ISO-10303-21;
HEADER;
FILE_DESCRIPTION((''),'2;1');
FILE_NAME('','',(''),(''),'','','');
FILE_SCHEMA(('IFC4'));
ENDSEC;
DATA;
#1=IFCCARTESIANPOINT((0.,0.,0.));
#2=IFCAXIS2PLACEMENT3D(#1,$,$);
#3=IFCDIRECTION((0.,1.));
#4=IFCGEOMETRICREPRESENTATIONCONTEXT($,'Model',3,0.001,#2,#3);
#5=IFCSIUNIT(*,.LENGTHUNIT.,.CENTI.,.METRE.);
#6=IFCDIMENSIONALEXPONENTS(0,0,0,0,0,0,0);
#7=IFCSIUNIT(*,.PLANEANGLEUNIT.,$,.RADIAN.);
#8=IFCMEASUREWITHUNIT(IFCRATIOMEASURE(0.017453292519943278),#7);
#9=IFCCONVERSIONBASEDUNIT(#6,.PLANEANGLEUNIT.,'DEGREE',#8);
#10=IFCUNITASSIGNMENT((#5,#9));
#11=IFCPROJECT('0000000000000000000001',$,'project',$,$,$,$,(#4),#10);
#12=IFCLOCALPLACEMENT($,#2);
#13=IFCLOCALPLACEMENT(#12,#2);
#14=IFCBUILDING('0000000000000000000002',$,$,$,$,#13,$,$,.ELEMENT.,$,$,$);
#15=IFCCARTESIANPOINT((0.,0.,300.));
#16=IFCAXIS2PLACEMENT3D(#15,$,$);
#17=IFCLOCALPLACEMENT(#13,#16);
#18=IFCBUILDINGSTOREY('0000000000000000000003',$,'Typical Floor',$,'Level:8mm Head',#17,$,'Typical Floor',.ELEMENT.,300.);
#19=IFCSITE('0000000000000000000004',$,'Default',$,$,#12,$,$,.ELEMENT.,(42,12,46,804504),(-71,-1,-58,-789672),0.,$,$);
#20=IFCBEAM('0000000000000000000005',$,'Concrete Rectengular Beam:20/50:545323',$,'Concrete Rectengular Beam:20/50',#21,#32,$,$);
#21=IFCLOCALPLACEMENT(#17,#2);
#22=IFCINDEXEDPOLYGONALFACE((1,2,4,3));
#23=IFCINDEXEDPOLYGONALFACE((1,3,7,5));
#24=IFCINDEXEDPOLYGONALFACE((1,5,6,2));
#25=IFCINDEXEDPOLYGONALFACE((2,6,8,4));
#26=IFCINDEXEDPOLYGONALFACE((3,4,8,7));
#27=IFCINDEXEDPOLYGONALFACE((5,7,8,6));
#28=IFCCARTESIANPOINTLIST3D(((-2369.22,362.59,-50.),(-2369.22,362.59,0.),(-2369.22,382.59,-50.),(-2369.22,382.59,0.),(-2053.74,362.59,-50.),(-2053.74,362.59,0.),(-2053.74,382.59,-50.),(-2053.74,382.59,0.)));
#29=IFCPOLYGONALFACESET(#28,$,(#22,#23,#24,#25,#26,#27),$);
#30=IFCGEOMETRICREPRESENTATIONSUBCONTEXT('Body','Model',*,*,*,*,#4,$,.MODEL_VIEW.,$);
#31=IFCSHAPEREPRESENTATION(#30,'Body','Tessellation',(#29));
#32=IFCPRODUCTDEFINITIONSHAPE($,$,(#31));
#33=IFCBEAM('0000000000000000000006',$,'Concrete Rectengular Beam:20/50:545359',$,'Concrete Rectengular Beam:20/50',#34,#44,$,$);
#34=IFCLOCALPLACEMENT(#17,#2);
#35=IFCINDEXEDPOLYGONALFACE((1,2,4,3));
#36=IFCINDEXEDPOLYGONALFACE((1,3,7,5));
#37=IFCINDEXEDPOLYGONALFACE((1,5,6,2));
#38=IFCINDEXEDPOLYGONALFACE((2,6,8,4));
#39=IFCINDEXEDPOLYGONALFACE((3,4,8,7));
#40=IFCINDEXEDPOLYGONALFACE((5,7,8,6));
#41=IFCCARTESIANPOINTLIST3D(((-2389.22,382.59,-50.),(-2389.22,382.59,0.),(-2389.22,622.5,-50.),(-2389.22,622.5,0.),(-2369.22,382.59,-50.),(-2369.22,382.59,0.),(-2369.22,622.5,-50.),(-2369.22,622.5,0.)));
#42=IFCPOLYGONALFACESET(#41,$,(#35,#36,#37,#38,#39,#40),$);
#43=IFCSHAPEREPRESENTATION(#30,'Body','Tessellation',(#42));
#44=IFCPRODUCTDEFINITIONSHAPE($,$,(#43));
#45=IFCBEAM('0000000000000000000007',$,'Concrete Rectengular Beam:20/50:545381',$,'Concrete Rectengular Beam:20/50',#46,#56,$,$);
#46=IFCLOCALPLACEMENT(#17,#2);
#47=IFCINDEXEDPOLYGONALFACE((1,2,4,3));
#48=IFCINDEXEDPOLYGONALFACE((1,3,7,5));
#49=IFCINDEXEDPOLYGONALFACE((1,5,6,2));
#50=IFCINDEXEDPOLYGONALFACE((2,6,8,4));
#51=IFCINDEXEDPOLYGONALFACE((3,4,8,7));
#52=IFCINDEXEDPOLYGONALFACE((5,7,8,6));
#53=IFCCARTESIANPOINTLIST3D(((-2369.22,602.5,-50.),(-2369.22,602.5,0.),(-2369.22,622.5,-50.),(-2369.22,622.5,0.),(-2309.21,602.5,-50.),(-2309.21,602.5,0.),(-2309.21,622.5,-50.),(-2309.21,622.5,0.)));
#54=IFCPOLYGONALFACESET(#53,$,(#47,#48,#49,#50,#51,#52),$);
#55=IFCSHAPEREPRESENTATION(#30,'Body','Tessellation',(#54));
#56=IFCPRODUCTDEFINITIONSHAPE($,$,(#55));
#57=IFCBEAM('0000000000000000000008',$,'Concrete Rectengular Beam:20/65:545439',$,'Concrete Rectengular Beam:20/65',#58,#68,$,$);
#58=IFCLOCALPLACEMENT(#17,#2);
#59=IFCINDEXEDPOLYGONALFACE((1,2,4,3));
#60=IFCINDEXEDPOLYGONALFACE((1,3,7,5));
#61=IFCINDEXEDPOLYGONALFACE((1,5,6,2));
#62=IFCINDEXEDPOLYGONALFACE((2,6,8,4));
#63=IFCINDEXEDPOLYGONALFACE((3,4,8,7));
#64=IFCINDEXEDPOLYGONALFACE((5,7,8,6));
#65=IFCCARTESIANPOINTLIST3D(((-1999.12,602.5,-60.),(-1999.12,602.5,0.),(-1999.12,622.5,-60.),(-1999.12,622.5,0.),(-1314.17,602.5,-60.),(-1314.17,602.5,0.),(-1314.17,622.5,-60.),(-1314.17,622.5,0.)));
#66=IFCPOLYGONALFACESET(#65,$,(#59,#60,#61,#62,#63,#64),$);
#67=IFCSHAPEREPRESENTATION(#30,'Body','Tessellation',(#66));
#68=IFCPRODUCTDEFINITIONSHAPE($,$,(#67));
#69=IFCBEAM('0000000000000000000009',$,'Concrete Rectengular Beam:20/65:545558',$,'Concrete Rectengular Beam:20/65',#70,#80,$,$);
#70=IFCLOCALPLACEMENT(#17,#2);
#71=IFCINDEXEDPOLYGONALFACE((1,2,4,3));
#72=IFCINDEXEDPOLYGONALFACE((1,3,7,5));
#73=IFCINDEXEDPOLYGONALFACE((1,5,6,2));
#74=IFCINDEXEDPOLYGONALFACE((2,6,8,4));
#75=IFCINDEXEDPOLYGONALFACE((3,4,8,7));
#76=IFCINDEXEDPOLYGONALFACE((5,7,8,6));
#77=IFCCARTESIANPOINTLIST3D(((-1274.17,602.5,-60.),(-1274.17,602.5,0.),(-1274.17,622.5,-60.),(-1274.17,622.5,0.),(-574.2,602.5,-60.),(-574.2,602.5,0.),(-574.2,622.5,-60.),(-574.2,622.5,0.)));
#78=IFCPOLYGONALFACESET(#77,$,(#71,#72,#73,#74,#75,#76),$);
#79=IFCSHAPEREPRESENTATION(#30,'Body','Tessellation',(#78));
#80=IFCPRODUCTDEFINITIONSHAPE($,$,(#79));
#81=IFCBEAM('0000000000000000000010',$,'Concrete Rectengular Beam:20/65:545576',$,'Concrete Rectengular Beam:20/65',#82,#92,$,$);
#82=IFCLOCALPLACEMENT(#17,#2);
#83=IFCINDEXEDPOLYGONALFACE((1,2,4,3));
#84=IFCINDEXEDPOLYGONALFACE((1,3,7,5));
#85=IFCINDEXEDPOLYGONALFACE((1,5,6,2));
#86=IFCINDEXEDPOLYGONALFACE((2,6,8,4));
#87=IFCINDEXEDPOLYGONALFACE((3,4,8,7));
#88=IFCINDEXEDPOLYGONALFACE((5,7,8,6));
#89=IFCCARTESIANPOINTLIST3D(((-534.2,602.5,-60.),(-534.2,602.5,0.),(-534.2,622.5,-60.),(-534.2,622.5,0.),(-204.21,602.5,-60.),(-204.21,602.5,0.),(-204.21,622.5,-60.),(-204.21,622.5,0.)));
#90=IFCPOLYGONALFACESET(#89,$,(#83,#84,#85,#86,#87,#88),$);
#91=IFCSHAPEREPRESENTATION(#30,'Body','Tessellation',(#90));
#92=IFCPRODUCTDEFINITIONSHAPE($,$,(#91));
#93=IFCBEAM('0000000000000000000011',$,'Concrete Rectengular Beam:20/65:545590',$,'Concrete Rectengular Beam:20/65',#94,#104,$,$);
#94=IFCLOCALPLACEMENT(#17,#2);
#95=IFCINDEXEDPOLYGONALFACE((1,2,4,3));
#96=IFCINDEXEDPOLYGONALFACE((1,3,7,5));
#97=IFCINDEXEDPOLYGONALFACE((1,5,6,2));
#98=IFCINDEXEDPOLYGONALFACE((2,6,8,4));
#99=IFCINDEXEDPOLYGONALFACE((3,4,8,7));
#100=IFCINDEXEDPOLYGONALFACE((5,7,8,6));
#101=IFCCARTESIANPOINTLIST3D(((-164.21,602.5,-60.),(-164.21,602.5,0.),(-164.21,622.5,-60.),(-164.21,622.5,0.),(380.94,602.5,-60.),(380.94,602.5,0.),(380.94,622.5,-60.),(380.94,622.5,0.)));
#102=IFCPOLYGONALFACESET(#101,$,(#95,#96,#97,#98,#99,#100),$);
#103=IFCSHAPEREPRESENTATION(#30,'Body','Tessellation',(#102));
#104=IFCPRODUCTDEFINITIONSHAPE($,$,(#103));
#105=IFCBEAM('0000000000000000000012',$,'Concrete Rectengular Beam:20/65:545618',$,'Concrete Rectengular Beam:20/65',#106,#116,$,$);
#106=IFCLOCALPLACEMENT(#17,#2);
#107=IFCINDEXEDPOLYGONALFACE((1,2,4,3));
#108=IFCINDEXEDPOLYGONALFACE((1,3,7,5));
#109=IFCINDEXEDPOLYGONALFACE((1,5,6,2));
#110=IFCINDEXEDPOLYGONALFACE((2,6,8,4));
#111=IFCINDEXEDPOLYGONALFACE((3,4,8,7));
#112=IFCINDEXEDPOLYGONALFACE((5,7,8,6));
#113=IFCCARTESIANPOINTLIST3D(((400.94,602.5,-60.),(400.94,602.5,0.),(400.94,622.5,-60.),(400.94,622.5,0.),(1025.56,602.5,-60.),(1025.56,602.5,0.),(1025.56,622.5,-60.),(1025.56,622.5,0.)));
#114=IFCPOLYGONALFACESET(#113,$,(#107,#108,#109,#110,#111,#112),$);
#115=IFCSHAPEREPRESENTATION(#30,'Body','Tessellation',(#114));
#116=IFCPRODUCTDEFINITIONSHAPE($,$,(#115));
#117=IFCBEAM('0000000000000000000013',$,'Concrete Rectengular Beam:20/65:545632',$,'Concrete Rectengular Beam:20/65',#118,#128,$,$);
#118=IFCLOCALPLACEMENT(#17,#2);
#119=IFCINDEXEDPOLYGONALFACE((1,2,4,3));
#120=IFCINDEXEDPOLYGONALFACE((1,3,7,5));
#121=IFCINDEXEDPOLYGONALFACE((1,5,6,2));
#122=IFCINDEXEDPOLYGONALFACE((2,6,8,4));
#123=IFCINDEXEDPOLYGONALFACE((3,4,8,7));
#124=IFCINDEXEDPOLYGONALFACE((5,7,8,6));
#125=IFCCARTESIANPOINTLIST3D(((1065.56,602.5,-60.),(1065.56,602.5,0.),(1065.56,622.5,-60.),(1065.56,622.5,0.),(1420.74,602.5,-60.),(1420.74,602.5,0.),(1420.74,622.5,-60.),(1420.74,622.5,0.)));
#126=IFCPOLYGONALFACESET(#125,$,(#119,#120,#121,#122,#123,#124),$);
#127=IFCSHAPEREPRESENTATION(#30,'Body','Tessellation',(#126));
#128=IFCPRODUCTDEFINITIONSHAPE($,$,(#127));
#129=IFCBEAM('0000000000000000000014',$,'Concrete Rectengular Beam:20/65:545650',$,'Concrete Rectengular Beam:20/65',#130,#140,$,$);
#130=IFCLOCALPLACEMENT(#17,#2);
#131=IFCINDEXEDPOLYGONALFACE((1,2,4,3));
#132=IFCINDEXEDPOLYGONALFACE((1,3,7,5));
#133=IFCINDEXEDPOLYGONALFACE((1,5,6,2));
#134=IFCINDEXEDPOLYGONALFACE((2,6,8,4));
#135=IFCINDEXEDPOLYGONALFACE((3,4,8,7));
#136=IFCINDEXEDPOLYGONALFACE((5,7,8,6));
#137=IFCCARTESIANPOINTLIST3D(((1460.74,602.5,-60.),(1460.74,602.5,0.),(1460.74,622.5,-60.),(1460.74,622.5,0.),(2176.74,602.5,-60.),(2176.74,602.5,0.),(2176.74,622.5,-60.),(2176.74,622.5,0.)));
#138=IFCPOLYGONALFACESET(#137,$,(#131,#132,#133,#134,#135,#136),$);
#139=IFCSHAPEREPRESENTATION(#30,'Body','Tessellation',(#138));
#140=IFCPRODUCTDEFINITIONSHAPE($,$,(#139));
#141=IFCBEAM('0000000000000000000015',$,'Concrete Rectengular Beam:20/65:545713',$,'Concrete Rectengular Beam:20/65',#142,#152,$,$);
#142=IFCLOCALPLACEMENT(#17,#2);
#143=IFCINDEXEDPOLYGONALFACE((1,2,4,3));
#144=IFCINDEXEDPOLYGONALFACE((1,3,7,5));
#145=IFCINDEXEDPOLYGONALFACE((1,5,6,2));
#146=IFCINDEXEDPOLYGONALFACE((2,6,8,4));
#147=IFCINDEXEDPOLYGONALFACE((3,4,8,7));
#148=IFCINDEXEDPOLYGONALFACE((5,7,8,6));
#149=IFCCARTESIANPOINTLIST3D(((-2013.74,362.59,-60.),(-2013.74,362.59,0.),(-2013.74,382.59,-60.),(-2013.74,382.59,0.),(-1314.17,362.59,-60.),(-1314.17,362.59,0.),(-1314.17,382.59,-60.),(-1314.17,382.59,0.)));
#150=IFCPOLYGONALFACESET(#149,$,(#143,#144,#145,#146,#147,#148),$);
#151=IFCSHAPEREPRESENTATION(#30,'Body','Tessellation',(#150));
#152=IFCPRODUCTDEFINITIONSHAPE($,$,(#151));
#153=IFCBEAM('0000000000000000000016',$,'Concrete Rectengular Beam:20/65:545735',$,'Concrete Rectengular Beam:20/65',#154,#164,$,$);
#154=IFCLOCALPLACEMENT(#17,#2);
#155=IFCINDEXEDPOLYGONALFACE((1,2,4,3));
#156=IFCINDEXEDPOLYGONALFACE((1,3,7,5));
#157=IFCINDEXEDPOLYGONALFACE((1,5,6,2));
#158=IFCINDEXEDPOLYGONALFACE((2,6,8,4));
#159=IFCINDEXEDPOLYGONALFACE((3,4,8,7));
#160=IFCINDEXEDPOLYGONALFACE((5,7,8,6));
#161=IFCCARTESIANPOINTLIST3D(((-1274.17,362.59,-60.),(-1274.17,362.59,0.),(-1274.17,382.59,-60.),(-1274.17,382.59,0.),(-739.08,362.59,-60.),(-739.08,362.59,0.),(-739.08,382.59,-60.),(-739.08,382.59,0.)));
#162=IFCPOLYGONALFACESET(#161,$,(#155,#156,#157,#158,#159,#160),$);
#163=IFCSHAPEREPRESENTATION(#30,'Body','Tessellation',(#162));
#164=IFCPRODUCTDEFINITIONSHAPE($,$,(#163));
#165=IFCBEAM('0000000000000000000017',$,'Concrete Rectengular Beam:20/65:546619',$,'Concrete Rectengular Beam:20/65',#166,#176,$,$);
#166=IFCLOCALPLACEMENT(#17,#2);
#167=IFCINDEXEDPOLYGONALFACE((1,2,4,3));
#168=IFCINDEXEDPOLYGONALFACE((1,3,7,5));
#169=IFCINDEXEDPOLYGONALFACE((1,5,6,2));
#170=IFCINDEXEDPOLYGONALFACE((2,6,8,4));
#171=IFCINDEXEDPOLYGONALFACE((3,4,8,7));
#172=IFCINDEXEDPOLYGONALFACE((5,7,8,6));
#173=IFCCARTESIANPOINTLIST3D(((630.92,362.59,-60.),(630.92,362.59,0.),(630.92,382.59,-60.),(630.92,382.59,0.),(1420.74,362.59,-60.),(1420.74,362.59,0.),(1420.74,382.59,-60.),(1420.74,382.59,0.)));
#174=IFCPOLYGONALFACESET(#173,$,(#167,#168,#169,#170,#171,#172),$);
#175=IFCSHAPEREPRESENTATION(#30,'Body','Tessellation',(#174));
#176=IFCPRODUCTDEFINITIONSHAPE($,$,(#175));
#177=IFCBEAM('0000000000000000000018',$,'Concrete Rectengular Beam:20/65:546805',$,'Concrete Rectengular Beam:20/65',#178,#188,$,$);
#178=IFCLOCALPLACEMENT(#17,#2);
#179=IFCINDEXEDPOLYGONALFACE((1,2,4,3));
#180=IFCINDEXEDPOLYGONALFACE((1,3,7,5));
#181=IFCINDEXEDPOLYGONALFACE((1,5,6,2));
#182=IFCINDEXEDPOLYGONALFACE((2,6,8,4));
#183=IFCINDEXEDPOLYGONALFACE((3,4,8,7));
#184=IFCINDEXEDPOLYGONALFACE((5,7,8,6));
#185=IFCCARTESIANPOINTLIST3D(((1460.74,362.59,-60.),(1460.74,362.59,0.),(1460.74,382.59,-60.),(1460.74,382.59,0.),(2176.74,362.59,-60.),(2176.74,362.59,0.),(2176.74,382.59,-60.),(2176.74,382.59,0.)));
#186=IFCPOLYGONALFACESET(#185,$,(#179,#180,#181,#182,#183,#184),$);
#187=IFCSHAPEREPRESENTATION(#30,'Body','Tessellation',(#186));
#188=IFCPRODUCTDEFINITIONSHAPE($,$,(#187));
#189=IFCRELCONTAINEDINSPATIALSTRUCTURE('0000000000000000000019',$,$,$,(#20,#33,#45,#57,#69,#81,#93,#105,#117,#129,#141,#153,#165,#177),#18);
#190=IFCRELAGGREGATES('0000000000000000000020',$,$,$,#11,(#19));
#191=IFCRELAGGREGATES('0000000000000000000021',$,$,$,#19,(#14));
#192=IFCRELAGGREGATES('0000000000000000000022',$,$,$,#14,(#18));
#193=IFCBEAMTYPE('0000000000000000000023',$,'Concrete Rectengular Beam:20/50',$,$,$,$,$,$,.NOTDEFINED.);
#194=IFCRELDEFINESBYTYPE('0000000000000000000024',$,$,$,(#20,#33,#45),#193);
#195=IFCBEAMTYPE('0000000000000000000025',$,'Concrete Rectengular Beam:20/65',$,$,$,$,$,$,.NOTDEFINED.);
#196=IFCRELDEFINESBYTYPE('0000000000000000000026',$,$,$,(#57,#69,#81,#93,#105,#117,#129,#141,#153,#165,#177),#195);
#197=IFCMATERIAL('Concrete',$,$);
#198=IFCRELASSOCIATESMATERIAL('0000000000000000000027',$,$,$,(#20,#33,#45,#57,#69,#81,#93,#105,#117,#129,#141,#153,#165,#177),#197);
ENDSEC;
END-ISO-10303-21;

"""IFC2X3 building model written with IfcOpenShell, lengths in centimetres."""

from ifc_helpers import new_model, entity, si_unit, converted_unit, direction, frame, frame_2d, origin, place, context, subcontext, project, spatial, rectangle, extrude, material, type_object, element, save


model = new_model("IFC2X3")

# Units and contexts
model_context = context("Model", 3, precision=0.001, world=origin(), true_north=direction((0.0, 1.0)))
body_context = subcontext(model_context, "Body", "Model", "MODEL_VIEW")
ifc_project = project(units=[si_unit("LENGTHUNIT", "METRE", prefix="CENTI"), converted_unit("PLANEANGLEUNIT", "DEGREE", entity("IfcRatioMeasure", 0.017453292519943278), si_unit("PLANEANGLEUNIT", "RADIAN"), dimensions=[0, 0, 0, 0, 0, 0, 0])], contexts=[model_context])

# Site, building, storey
site_placement = place(None, origin())
site = spatial("IfcSite", under=ifc_project, at=site_placement, Name="Default", CompositionType="ELEMENT", RefLatitude=(42, 12, 46, 804504), RefLongitude=(-71, -1, -58, -789672), RefElevation=0.0)
building_placement = place(site_placement, origin())
building = spatial("IfcBuilding", under=site, at=building_placement, CompositionType="ELEMENT")
storey_placement = place(building_placement, frame((0.0, 0.0, 300.0)))
storey = spatial("IfcBuildingStorey", under=building, at=storey_placement, Name="Typical Floor", ObjectType="Level:8mm Head", LongName="Typical Floor", CompositionType="ELEMENT", Elevation=300.0)

# Beams
ifc_material = material(Name="Concrete")
beam_type_1 = type_object("IfcBeamType", Name="Concrete Rectengular Beam:20/50", PredefinedType="NOTDEFINED")
beam_1_placement = place(storey_placement, frame((-2379.22, 372.59, 0.0)))
element("IfcBeam", 1, at=beam_1_placement, inside=storey, type_object=beam_type_1, material=ifc_material, Name="Concrete Rectengular Beam:20/50:545323", ObjectType="Concrete Rectengular Beam:20/50", context=body_context, shape_type="SweptSolid", body=[
    extrude(rectangle(XDim=50.0, YDim=20.0, at=frame_2d((0.0, 0.0), x_axis=(1.0, 0.0))), frame((10.0, 0.0, -25.0), z_axis=(1.0, 0.0, 0.0), x_axis=(0.0, 0.0, -1.0)), (0.0, 0.0, 1.0), 315.48),
])
beam_2_placement = place(storey_placement, frame((-2379.22, 372.59, 0.0), z_axis=(0.0, 0.0, 1.0), x_axis=(0.0, 1.0, 0.0)))
element("IfcBeam", 2, at=beam_2_placement, inside=storey, type_object=beam_type_1, material=ifc_material, Name="Concrete Rectengular Beam:20/50:545359", ObjectType="Concrete Rectengular Beam:20/50", context=body_context, shape_type="SweptSolid", body=[
    extrude(rectangle(XDim=50.0, YDim=20.0, at=frame_2d((0.0, 0.0), x_axis=(1.0, 0.0))), frame((10.0, 0.0, -25.0), z_axis=(1.0, 0.0, 0.0), x_axis=(0.0, 0.0, -1.0)), (0.0, 0.0, 1.0), 239.92),
])
beam_3_placement = place(storey_placement, frame((-2379.22, 612.5, 0.0)))
element("IfcBeam", 3, at=beam_3_placement, inside=storey, type_object=beam_type_1, material=ifc_material, Name="Concrete Rectengular Beam:20/50:545381", ObjectType="Concrete Rectengular Beam:20/50", context=body_context, shape_type="SweptSolid", body=[
    extrude(rectangle(XDim=50.0, YDim=20.0, at=frame_2d((0.0, 0.0), x_axis=(1.0, 0.0))), frame((10.0, 0.0, -25.0), z_axis=(1.0, 0.0, 0.0), x_axis=(0.0, 0.0, -1.0)), (0.0, 0.0, 1.0), 60.01),
])
beam_type_2 = type_object("IfcBeamType", Name="Concrete Rectengular Beam:20/65", PredefinedType="NOTDEFINED")
beam_4_placement = place(storey_placement, frame((-2009.12, 612.5, 0.0)))
element("IfcBeam", 4, at=beam_4_placement, inside=storey, type_object=beam_type_2, material=ifc_material, Name="Concrete Rectengular Beam:20/65:545439", ObjectType="Concrete Rectengular Beam:20/65", context=body_context, shape_type="SweptSolid", body=[
    extrude(rectangle(XDim=60.0, YDim=20.0, at=frame_2d((0.0, 0.0), x_axis=(1.0, 0.0))), frame((10.0, 0.0, -30.0), z_axis=(1.0, 0.0, 0.0), x_axis=(0.0, 0.0, -1.0)), (0.0, 0.0, 1.0), 684.94),
])
beam_5_placement = place(storey_placement, frame((-1294.17, 612.5, 0.0)))
element("IfcBeam", 5, at=beam_5_placement, inside=storey, type_object=beam_type_2, material=ifc_material, Name="Concrete Rectengular Beam:20/65:545558", ObjectType="Concrete Rectengular Beam:20/65", context=body_context, shape_type="SweptSolid", body=[
    extrude(rectangle(XDim=60.0, YDim=20.0, at=frame_2d((0.0, 0.0), x_axis=(1.0, 0.0))), frame((20.0, 0.0, -30.0), z_axis=(1.0, 0.0, 0.0), x_axis=(0.0, 0.0, -1.0)), (0.0, 0.0, 1.0), 699.98),
])
beam_6_placement = place(storey_placement, frame((-554.2, 612.5, 0.0)))
element("IfcBeam", 6, at=beam_6_placement, inside=storey, type_object=beam_type_2, material=ifc_material, Name="Concrete Rectengular Beam:20/65:545576", ObjectType="Concrete Rectengular Beam:20/65", context=body_context, shape_type="SweptSolid", body=[
    extrude(rectangle(XDim=60.0, YDim=20.0, at=frame_2d((0.0, 0.0), x_axis=(1.0, 0.0))), frame((20.0, 0.0, -30.0), z_axis=(1.0, 0.0, 0.0), x_axis=(0.0, 0.0, -1.0)), (0.0, 0.0, 1.0), 329.99),
])
beam_7_placement = place(storey_placement, frame((-184.21, 612.5, 0.0)))
element("IfcBeam", 7, at=beam_7_placement, inside=storey, type_object=beam_type_2, material=ifc_material, Name="Concrete Rectengular Beam:20/65:545590", ObjectType="Concrete Rectengular Beam:20/65", context=body_context, shape_type="SweptSolid", body=[
    extrude(rectangle(XDim=60.0, YDim=20.0, at=frame_2d((0.0, 0.0), x_axis=(1.0, 0.0))), frame((20.0, 0.0, -30.0), z_axis=(1.0, 0.0, 0.0), x_axis=(0.0, 0.0, -1.0)), (0.0, 0.0, 1.0), 545.15),
])
beam_8_placement = place(storey_placement, frame((390.94, 612.5, 0.0)))
element("IfcBeam", 8, at=beam_8_placement, inside=storey, type_object=beam_type_2, material=ifc_material, Name="Concrete Rectengular Beam:20/65:545618", ObjectType="Concrete Rectengular Beam:20/65", context=body_context, shape_type="SweptSolid", body=[
    extrude(rectangle(XDim=60.0, YDim=20.0, at=frame_2d((0.0, 0.0), x_axis=(1.0, 0.0))), frame((10.0, 0.0, -30.0), z_axis=(1.0, 0.0, 0.0), x_axis=(0.0, 0.0, -1.0)), (0.0, 0.0, 1.0), 624.62),
])
beam_9_placement = place(storey_placement, frame((1045.56, 612.5, 0.0)))
element("IfcBeam", 9, at=beam_9_placement, inside=storey, type_object=beam_type_2, material=ifc_material, Name="Concrete Rectengular Beam:20/65:545632", ObjectType="Concrete Rectengular Beam:20/65", context=body_context, shape_type="SweptSolid", body=[
    extrude(rectangle(XDim=60.0, YDim=20.0, at=frame_2d((0.0, 0.0), x_axis=(1.0, 0.0))), frame((20.0, 0.0, -30.0), z_axis=(1.0, 0.0, 0.0), x_axis=(0.0, 0.0, -1.0)), (0.0, 0.0, 1.0), 355.18),
])
beam_10_placement = place(storey_placement, frame((1440.74, 612.5, 0.0)))
element("IfcBeam", 10, at=beam_10_placement, inside=storey, type_object=beam_type_2, material=ifc_material, Name="Concrete Rectengular Beam:20/65:545650", ObjectType="Concrete Rectengular Beam:20/65", context=body_context, shape_type="SweptSolid", body=[
    extrude(rectangle(XDim=60.0, YDim=20.0, at=frame_2d((0.0, 0.0), x_axis=(1.0, 0.0))), frame((20.0, 0.0, -30.0), z_axis=(1.0, 0.0, 0.0), x_axis=(0.0, 0.0, -1.0)), (0.0, 0.0, 1.0), 716.0),
])
beam_11_placement = place(storey_placement, frame((-2033.74, 372.59, 0.0)))
element("IfcBeam", 11, at=beam_11_placement, inside=storey, type_object=beam_type_2, material=ifc_material, Name="Concrete Rectengular Beam:20/65:545713", ObjectType="Concrete Rectengular Beam:20/65", context=body_context, shape_type="SweptSolid", body=[
    extrude(rectangle(XDim=60.0, YDim=20.0, at=frame_2d((0.0, 0.0), x_axis=(1.0, 0.0))), frame((20.0, 0.0, -30.0), z_axis=(1.0, 0.0, 0.0), x_axis=(0.0, 0.0, -1.0)), (0.0, 0.0, 1.0), 699.56),
])
beam_12_placement = place(storey_placement, frame((-1294.17, 372.59, 0.0)))
element("IfcBeam", 12, at=beam_12_placement, inside=storey, type_object=beam_type_2, material=ifc_material, Name="Concrete Rectengular Beam:20/65:545735", ObjectType="Concrete Rectengular Beam:20/65", context=body_context, shape_type="SweptSolid", body=[
    extrude(rectangle(XDim=60.0, YDim=20.0, at=frame_2d((0.0, 0.0), x_axis=(1.0, 0.0))), frame((20.0, 0.0, -30.0), z_axis=(1.0, 0.0, 0.0), x_axis=(0.0, 0.0, -1.0)), (0.0, 0.0, 1.0), 535.09),
])
beam_13_placement = place(storey_placement, frame((1440.74, 372.59, 0.0), z_axis=(0.0, 0.0, 1.0), x_axis=(-1.0, 0.0, 0.0)))
element("IfcBeam", 13, at=beam_13_placement, inside=storey, type_object=beam_type_2, material=ifc_material, Name="Concrete Rectengular Beam:20/65:546619", ObjectType="Concrete Rectengular Beam:20/65", context=body_context, shape_type="SweptSolid", body=[
    extrude(rectangle(XDim=60.0, YDim=20.0, at=frame_2d((0.0, 0.0), x_axis=(1.0, 0.0))), frame((20.0, 0.0, -30.0), z_axis=(1.0, 0.0, 0.0), x_axis=(0.0, 0.0, -1.0)), (0.0, 0.0, 1.0), 789.82),
])
beam_14_placement = place(storey_placement, frame((1440.74, 372.59, 0.0)))
element("IfcBeam", 14, at=beam_14_placement, inside=storey, type_object=beam_type_2, material=ifc_material, Name="Concrete Rectengular Beam:20/65:546805", ObjectType="Concrete Rectengular Beam:20/65", context=body_context, shape_type="SweptSolid", body=[
    extrude(rectangle(XDim=60.0, YDim=20.0, at=frame_2d((0.0, 0.0), x_axis=(1.0, 0.0))), frame((20.0, 0.0, -30.0), z_axis=(1.0, 0.0, 0.0), x_axis=(0.0, 0.0, -1.0)), (0.0, 0.0, 1.0), 716.0),
])

save(model, "model.ifc")
